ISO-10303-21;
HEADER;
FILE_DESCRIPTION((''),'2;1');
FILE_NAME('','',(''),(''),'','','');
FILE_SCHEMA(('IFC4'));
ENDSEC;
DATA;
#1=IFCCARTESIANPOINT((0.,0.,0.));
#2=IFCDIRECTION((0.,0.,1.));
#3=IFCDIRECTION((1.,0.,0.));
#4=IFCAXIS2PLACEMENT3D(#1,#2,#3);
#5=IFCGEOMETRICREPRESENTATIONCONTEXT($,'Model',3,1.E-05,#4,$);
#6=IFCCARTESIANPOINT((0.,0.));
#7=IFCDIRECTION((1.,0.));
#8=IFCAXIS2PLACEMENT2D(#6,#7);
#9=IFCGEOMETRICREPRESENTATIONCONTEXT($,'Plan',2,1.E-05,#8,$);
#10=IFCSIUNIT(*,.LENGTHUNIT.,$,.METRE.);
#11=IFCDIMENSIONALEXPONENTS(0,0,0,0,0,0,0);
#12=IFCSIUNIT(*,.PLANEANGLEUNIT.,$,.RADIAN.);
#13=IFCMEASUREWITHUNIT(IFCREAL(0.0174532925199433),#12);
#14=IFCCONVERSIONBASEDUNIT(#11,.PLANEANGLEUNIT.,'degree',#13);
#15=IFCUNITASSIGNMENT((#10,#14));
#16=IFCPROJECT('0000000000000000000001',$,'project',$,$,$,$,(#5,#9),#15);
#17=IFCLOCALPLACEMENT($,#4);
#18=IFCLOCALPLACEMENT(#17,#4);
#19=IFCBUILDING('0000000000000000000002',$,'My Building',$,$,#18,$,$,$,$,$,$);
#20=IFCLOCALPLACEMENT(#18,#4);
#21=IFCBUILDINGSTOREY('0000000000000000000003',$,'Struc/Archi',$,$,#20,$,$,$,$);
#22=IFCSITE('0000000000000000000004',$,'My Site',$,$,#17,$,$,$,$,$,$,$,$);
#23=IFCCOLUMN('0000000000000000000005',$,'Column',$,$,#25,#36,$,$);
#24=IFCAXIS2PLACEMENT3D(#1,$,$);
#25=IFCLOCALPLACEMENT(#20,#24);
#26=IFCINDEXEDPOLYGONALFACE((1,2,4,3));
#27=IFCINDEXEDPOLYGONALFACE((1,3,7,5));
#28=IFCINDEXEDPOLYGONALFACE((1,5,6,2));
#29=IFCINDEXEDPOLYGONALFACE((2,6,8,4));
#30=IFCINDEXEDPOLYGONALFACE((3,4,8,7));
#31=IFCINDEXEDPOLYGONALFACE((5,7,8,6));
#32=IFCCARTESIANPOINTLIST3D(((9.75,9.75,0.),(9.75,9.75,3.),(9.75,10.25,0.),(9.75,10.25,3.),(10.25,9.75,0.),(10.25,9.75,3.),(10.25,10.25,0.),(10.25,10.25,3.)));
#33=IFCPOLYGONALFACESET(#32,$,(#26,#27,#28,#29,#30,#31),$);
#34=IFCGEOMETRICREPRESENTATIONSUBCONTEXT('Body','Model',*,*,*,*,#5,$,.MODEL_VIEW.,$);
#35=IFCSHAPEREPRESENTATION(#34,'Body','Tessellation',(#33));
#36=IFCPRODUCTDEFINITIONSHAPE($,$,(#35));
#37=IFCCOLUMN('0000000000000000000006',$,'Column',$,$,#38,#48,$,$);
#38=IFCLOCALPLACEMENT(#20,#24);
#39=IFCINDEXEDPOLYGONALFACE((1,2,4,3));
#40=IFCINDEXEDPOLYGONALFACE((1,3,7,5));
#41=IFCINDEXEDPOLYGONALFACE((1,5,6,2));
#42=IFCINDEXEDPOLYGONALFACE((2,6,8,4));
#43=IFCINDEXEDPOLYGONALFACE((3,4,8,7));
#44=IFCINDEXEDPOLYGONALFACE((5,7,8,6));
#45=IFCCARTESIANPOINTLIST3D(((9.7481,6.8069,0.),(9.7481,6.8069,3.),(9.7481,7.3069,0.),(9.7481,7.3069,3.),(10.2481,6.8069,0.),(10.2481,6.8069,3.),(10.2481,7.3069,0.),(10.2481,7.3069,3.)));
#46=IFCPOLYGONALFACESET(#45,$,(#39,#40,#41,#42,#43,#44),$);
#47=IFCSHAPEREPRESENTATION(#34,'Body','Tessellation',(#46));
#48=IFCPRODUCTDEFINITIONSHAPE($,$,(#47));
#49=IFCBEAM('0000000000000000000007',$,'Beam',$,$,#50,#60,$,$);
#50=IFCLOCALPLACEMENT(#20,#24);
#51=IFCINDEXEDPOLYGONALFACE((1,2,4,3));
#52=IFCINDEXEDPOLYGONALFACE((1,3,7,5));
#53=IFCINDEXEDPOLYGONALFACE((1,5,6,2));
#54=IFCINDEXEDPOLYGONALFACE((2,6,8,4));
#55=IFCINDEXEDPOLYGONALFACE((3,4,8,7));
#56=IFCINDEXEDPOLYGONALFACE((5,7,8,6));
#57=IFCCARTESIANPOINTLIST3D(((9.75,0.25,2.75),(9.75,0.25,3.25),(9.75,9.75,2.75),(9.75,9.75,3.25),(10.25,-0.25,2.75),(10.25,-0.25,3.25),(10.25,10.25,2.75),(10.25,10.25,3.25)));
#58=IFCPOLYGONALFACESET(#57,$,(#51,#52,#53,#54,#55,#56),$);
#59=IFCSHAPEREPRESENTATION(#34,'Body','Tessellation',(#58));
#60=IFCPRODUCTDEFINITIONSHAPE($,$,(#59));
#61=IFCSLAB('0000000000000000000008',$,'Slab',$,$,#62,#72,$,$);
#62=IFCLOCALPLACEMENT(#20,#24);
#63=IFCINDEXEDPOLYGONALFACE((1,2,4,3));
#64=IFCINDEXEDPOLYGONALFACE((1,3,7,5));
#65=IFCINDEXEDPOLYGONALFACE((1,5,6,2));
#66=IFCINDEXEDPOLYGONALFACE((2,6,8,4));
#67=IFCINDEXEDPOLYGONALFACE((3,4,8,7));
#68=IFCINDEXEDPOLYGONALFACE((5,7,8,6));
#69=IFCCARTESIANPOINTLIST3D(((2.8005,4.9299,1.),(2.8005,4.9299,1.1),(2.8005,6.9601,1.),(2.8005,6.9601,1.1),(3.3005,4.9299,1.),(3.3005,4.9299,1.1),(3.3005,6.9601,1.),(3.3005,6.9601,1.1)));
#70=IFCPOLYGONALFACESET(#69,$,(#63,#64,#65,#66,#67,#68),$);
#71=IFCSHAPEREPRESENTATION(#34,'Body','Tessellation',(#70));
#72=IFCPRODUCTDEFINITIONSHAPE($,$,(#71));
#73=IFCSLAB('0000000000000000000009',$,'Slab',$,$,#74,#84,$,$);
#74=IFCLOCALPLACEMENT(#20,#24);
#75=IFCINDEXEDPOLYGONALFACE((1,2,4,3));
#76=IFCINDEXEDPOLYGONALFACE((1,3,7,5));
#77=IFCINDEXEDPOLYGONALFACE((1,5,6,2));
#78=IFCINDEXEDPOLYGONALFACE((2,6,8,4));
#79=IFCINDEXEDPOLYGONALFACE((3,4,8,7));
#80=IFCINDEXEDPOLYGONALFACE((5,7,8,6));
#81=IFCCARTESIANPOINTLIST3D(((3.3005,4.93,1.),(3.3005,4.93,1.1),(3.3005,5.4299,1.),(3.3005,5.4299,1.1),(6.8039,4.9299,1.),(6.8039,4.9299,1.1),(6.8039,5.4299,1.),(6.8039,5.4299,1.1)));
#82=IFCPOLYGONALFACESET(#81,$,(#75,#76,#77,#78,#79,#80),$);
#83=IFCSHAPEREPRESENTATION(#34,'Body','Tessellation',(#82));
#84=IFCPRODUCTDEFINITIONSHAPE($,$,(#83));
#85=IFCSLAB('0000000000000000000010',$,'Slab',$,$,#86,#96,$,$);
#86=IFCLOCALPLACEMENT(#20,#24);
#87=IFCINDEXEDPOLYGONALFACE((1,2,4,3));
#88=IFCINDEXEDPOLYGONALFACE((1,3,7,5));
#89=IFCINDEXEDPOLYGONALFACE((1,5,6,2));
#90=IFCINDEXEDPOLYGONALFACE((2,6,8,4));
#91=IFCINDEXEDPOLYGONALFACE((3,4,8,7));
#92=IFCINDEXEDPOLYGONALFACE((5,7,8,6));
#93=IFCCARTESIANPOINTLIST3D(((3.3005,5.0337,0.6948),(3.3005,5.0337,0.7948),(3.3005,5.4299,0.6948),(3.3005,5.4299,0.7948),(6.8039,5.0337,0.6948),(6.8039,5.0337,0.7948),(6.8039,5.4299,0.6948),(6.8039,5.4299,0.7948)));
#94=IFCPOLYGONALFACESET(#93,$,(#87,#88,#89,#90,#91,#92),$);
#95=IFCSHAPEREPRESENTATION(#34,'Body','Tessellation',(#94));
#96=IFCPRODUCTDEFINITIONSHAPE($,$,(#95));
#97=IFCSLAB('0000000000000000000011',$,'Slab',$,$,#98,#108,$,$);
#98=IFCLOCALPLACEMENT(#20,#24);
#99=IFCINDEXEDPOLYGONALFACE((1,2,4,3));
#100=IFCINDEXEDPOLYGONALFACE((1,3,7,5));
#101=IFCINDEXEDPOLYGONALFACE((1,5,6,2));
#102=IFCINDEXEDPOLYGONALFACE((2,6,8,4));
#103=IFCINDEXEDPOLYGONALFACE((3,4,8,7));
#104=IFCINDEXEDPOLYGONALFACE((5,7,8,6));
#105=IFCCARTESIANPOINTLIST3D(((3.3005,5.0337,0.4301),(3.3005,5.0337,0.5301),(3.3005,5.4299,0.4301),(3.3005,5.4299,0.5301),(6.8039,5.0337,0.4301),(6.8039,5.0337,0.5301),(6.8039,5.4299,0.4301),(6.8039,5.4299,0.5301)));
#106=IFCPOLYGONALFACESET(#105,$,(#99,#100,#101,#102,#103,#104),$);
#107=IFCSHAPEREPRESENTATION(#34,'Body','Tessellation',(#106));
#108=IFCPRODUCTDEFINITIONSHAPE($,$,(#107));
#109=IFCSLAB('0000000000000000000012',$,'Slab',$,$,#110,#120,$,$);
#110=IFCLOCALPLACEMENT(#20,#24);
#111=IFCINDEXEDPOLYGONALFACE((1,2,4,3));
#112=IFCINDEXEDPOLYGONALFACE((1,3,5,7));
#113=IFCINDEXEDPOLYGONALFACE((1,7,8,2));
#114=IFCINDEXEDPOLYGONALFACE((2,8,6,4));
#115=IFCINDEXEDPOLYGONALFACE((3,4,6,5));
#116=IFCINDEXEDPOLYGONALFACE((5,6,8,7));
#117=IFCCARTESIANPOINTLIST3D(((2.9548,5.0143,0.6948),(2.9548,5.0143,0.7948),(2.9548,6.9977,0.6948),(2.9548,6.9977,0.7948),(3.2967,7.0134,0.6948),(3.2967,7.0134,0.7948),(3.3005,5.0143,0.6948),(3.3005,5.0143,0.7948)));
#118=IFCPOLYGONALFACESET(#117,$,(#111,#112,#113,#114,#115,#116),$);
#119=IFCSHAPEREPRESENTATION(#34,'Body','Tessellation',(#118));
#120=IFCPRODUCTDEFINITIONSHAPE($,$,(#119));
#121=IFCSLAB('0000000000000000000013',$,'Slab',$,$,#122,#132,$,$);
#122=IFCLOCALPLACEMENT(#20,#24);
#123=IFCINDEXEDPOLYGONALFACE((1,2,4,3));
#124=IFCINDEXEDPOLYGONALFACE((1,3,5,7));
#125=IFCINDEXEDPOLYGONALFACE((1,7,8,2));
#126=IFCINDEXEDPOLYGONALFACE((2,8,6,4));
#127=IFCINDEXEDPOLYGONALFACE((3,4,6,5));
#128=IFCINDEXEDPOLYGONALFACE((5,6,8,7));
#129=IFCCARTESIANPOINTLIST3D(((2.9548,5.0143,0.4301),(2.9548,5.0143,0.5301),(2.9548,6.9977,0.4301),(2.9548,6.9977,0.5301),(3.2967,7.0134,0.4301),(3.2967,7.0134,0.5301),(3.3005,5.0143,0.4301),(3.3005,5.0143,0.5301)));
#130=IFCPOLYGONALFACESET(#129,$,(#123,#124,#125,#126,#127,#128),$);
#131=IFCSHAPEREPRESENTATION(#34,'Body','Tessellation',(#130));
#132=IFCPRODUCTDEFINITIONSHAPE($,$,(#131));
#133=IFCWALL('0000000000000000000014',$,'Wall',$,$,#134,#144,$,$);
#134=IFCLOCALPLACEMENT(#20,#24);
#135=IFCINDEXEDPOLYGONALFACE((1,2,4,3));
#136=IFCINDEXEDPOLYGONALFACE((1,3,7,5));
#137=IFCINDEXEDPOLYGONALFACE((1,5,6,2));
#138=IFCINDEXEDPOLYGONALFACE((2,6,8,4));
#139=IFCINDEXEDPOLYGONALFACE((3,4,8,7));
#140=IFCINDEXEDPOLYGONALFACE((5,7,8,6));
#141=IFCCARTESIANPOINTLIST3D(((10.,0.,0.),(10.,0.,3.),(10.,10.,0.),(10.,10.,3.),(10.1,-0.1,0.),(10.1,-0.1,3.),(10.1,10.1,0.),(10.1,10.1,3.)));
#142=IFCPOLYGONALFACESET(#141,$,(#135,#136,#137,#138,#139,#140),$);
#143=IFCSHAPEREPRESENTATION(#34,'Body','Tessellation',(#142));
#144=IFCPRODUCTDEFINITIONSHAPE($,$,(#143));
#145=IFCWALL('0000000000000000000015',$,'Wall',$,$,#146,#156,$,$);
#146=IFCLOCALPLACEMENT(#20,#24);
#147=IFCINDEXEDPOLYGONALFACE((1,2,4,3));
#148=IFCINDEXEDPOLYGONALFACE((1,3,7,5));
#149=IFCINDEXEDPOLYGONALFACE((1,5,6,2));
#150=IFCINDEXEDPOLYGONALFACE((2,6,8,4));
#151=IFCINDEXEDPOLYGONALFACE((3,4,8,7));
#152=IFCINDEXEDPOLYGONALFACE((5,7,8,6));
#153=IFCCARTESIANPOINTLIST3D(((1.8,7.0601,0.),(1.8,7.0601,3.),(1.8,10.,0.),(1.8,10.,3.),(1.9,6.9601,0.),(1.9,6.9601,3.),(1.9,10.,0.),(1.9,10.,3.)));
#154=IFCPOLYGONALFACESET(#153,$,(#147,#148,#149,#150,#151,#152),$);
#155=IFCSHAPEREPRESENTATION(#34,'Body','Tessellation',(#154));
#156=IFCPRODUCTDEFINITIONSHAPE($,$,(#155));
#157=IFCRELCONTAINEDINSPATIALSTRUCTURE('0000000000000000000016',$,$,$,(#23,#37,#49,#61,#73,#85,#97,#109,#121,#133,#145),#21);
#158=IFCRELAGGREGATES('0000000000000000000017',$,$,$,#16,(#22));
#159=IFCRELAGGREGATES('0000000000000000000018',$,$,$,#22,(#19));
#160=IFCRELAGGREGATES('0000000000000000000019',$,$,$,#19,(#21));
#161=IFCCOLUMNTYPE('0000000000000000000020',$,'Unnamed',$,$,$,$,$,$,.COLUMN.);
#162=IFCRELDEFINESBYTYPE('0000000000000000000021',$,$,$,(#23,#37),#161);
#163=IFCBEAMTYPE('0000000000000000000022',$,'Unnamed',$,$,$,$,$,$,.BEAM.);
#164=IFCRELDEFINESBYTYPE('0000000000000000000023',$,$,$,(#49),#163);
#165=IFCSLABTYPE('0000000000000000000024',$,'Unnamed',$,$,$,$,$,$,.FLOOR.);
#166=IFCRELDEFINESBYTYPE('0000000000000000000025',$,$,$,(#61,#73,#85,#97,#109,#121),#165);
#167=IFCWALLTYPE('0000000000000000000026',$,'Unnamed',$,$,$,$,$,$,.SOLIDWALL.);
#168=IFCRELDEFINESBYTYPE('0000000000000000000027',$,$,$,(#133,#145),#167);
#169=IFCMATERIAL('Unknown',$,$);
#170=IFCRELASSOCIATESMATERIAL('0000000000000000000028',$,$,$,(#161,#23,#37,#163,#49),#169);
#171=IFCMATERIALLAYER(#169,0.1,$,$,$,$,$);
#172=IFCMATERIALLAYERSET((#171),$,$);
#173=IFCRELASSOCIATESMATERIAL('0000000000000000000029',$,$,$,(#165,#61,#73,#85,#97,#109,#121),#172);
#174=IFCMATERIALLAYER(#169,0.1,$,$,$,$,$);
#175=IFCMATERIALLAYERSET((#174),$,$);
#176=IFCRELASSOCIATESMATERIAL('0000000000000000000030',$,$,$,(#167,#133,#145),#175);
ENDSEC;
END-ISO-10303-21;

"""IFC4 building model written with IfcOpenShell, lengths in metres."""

from ifc_helpers import new_model, entity, si_unit, converted_unit, frame, origin_with_axes, origin_2d_with_axis, place, context, subcontext, project, spatial, line, indexed_curve, rectangle, outline, extrude, clip, halfspace, material, layer, layer_set, layer_usage, material_profile, profile_set, profile_usage, type_object, element, save


model = new_model("IFC4")

# Units and contexts
model_context = context("Model", 3, precision=1e-05, world=origin_with_axes())
plan_context = context("Plan", 2, precision=1e-05, world=origin_2d_with_axis())
body_context_1 = subcontext(model_context, "Body", "Model", "MODEL_VIEW")
ifc_project = project(units=[si_unit("LENGTHUNIT", "METRE"), converted_unit("PLANEANGLEUNIT", "degree", entity("IfcReal", 0.0174532925199433), si_unit("PLANEANGLEUNIT", "RADIAN"), dimensions=[0, 0, 0, 0, 0, 0, 0])], contexts=[model_context, plan_context])

# Site, building, storey
site_placement = place(None, origin_with_axes())
site = spatial("IfcSite", under=ifc_project, at=site_placement, Name="My Site")
building_placement = place(site_placement, origin_with_axes())
building = spatial("IfcBuilding", under=site, at=building_placement, Name="My Building")
storey_placement = place(building_placement, origin_with_axes())
storey = spatial("IfcBuildingStorey", under=building, at=storey_placement, Name="Struc/Archi")

# Columns
ifc_material = material(Name="Unknown")
ifc_material_profile_1 = material_profile(ifc_material, rectangle(XDim=0.5, YDim=0.5))
ifc_profile_set_1 = profile_set([ifc_material_profile_1])
ifc_profile_usage_1 = profile_usage(ifc_profile_set_1, cardinal=5)
column_type = type_object("IfcColumnType", Name="Unnamed", PredefinedType="COLUMN", material=ifc_profile_set_1)
column_1_placement = place(storey_placement, frame((10.0, 10.0, 0.0), z_axis=(0.0, 0.0, 1.0), x_axis=(1.0, 0.0, 0.0)))
element("IfcColumn", 1, at=column_1_placement, inside=storey, type_object=column_type, material=ifc_profile_usage_1, Name="Column", context=body_context_1, shape_type="SweptSolid", body=[
    extrude(rectangle(XDim=0.5, YDim=0.5), origin_with_axes(), (0.0, 0.0, 1.0), 3.0),
])
ifc_profile_usage_2 = profile_usage(ifc_profile_set_1, cardinal=5)
column_2_placement = place(storey_placement, frame((9.9981, 7.0569, 0.0), z_axis=(0.0, 0.0, 1.0), x_axis=(1.0, 0.0, 0.0)))
element("IfcColumn", 2, at=column_2_placement, inside=storey, type_object=column_type, material=ifc_profile_usage_2, Name="Column", context=body_context_1, shape_type="SweptSolid", body=[
    extrude(rectangle(XDim=0.5, YDim=0.5), origin_with_axes(), (0.0, 0.0, 1.0), 3.0),
])

# Beam
ifc_material_profile_2 = material_profile(ifc_material, rectangle(XDim=0.5, YDim=0.5))
ifc_profile_set_2 = profile_set([ifc_material_profile_2])
ifc_profile_usage_3 = profile_usage(ifc_profile_set_2, cardinal=5)
beam_type = type_object("IfcBeamType", Name="Unnamed", PredefinedType="BEAM", material=ifc_profile_set_2)
beam_placement = place(storey_placement, frame((10.0, 10.25, 3.0), z_axis=(0.0, -1.0, 0.0), x_axis=(1.0, 0.0, 0.0)))
element("IfcBeam", 3, at=beam_placement, inside=storey, type_object=beam_type, material=ifc_profile_usage_3, Name="Beam", context=body_context_1, shape_type="Clipping", body=[
    clip(clip(extrude(rectangle(XDim=0.5, YDim=0.5), origin_with_axes(), (0.0, 0.0, 1.0), 10.5), halfspace(frame((0.25, -3.0, 10.5), z_axis=(-0.707107, 0.0, 0.707107), x_axis=(0.0, 1.0, 0.0)), False)), halfspace(frame((0.25, -3.0, 0.0), z_axis=(-0.707107, 0.0, -0.707107), x_axis=(0.0, 1.0, 0.0)), False)),
])

# Slabs
ifc_layer_1 = layer(ifc_material, 0.1)
ifc_layer_set_1 = layer_set([ifc_layer_1])
ifc_layer_usage_1 = layer_usage(ifc_layer_set_1, "AXIS3", "POSITIVE", -0.1)
slab_type = type_object("IfcSlabType", Name="Unnamed", PredefinedType="FLOOR", material=ifc_layer_set_1)
slab_1_placement = place(storey_placement, frame((2.8005, 6.9601, 1.1), z_axis=(0.0, 0.0, 1.0), x_axis=(1.0, 0.0, 0.0)))
element("IfcSlab", 4, at=slab_1_placement, inside=storey, type_object=slab_type, material=ifc_layer_usage_1, Name="Slab", context=body_context_1, shape_type="SweptSolid", body=[
    extrude(outline(indexed_curve([(0.0, 0.0), (0.5, 0.0), (0.5, -2.0301), (0.0, -2.0301), (0.0, 0.0)])), frame((0.0, 0.0, -0.1), z_axis=(0.0, 0.0, 1.0), x_axis=(1.0, 0.0, 0.0)), (0.0, 0.0, 1.0), 0.1),
])
ifc_layer_usage_2 = layer_usage(ifc_layer_set_1, "AXIS3", "POSITIVE", -0.1)
slab_2_placement = place(storey_placement, frame((6.8039, 4.9299, 1.1), z_axis=(0.0, 0.0, 1.0), x_axis=(1.0, 0.0, 0.0)))
element("IfcSlab", 5, at=slab_2_placement, inside=storey, type_object=slab_type, material=ifc_layer_usage_2, Name="Slab", context=body_context_1, shape_type="SweptSolid", body=[
    extrude(outline(indexed_curve([(0.0, 0.0), (0.0, 0.5), (-3.5034, 0.5), (-3.5034, 0.0001), (0.0, 0.0)])), frame((0.0, 0.0, -0.1), z_axis=(0.0, 0.0, 1.0), x_axis=(1.0, 0.0, 0.0)), (0.0, 0.0, 1.0), 0.1),
])
ifc_layer_usage_3 = layer_usage(ifc_layer_set_1, "AXIS3", "POSITIVE", -0.1)
slab_3_placement = place(storey_placement, frame((3.3005, 5.4299, 0.7948), z_axis=(0.0, 0.0, 1.0), x_axis=(1.0, 0.0, 0.0)))
element("IfcSlab", 6, at=slab_3_placement, inside=storey, type_object=slab_type, material=ifc_layer_usage_3, Name="Slab", context=body_context_1, shape_type="SweptSolid", body=[
    extrude(outline(indexed_curve([(0.0, 0.0), (3.5034, 0.0), (3.5034, -0.3962), (0.0, -0.3962), (0.0, 0.0)])), frame((0.0, 0.0, -0.1), z_axis=(0.0, 0.0, 1.0), x_axis=(1.0, 0.0, 0.0)), (0.0, 0.0, 1.0), 0.1),
])
ifc_layer_usage_4 = layer_usage(ifc_layer_set_1, "AXIS3", "POSITIVE", -0.1)
slab_4_placement = place(storey_placement, frame((3.3005, 5.4299, 0.5301), z_axis=(0.0, 0.0, 1.0), x_axis=(1.0, 0.0, 0.0)))
element("IfcSlab", 7, at=slab_4_placement, inside=storey, type_object=slab_type, material=ifc_layer_usage_4, Name="Slab", context=body_context_1, shape_type="SweptSolid", body=[
    extrude(outline(indexed_curve([(0.0, 0.0), (3.5034, 0.0), (3.5034, -0.3962), (0.0, -0.3962), (0.0, 0.0)])), frame((0.0, 0.0, -0.1), z_axis=(0.0, 0.0, 1.0), x_axis=(1.0, 0.0, 0.0)), (0.0, 0.0, 1.0), 0.1),
])
ifc_layer_usage_5 = layer_usage(ifc_layer_set_1, "AXIS3", "POSITIVE", -0.1)
slab_5_placement = place(storey_placement, frame((3.2967, 7.0134, 0.7948), z_axis=(0.0, 0.0, 1.0), x_axis=(1.0, 0.0, 0.0)))
element("IfcSlab", 8, at=slab_5_placement, inside=storey, type_object=slab_type, material=ifc_layer_usage_5, Name="Slab", context=body_context_1, shape_type="SweptSolid", body=[
    extrude(outline(indexed_curve([(0.0, 0.0), (0.0038, -1.9991), (-0.3419, -1.9991), (-0.3419, -0.0157), (0.0, 0.0)])), frame((0.0, 0.0, -0.1), z_axis=(0.0, 0.0, 1.0), x_axis=(1.0, 0.0, 0.0)), (0.0, 0.0, 1.0), 0.1),
])
ifc_layer_usage_6 = layer_usage(ifc_layer_set_1, "AXIS3", "POSITIVE", -0.1)
slab_6_placement = place(storey_placement, frame((3.2967, 7.0134, 0.5301), z_axis=(0.0, 0.0, 1.0), x_axis=(1.0, 0.0, 0.0)))
element("IfcSlab", 9, at=slab_6_placement, inside=storey, type_object=slab_type, material=ifc_layer_usage_6, Name="Slab", context=body_context_1, shape_type="SweptSolid", body=[
    extrude(outline(indexed_curve([(0.0, 0.0), (0.0038, -1.9991), (-0.3419, -1.9991), (-0.3419, -0.0157), (0.0, 0.0)])), frame((0.0, 0.0, -0.1), z_axis=(0.0, 0.0, 1.0), x_axis=(1.0, 0.0, 0.0)), (0.0, 0.0, 1.0), 0.1),
])

# Walls
ifc_layer_2 = layer(ifc_material, 0.1)
ifc_layer_set_2 = layer_set([ifc_layer_2])
ifc_layer_usage_7 = layer_usage(ifc_layer_set_2, "AXIS2", "POSITIVE", 0.0)
wall_type = type_object("IfcWallType", Name="Unnamed", PredefinedType="SOLIDWALL", material=ifc_layer_set_2)
wall_1_placement = place(storey_placement, frame((10.0, 10.0, 0.0), z_axis=(0.0, 0.0, 1.0), x_axis=(0.0, -1.0, 0.0)))
element("IfcWall", 10, at=wall_1_placement, inside=storey, type_object=wall_type, material=ifc_layer_usage_7, Name="Wall", context=body_context_1, shape_type="SweptSolid", body=[
    extrude(outline(indexed_curve([(0.0, 0.0), (-0.1, 0.1), (10.1, 0.1), (10.0, 0.0)], segments=[line(1, 2, 3, 4, 1)])), origin_with_axes(), (0.0, 0.0, 1.0), 3.0),
])
ifc_layer_usage_8 = layer_usage(ifc_layer_set_2, "AXIS2", "POSITIVE", 0.0)
wall_2_placement = place(storey_placement, frame((1.9, 6.9601, 0.0), z_axis=(0.0, 0.0, 1.0), x_axis=(0.0, 1.0, 0.0)))
element("IfcWall", 11, at=wall_2_placement, inside=storey, type_object=wall_type, material=ifc_layer_usage_8, Name="Wall", context=body_context_1, shape_type="SweptSolid", body=[
    extrude(outline(indexed_curve([(0.0, 0.0), (0.1, 0.1), (3.0399, 0.1), (3.0399, 0.0)], segments=[line(1, 2, 3, 4, 1)])), origin_with_axes(), (0.0, 0.0, 1.0), 3.0),
])

save(model, "model.ifc")
